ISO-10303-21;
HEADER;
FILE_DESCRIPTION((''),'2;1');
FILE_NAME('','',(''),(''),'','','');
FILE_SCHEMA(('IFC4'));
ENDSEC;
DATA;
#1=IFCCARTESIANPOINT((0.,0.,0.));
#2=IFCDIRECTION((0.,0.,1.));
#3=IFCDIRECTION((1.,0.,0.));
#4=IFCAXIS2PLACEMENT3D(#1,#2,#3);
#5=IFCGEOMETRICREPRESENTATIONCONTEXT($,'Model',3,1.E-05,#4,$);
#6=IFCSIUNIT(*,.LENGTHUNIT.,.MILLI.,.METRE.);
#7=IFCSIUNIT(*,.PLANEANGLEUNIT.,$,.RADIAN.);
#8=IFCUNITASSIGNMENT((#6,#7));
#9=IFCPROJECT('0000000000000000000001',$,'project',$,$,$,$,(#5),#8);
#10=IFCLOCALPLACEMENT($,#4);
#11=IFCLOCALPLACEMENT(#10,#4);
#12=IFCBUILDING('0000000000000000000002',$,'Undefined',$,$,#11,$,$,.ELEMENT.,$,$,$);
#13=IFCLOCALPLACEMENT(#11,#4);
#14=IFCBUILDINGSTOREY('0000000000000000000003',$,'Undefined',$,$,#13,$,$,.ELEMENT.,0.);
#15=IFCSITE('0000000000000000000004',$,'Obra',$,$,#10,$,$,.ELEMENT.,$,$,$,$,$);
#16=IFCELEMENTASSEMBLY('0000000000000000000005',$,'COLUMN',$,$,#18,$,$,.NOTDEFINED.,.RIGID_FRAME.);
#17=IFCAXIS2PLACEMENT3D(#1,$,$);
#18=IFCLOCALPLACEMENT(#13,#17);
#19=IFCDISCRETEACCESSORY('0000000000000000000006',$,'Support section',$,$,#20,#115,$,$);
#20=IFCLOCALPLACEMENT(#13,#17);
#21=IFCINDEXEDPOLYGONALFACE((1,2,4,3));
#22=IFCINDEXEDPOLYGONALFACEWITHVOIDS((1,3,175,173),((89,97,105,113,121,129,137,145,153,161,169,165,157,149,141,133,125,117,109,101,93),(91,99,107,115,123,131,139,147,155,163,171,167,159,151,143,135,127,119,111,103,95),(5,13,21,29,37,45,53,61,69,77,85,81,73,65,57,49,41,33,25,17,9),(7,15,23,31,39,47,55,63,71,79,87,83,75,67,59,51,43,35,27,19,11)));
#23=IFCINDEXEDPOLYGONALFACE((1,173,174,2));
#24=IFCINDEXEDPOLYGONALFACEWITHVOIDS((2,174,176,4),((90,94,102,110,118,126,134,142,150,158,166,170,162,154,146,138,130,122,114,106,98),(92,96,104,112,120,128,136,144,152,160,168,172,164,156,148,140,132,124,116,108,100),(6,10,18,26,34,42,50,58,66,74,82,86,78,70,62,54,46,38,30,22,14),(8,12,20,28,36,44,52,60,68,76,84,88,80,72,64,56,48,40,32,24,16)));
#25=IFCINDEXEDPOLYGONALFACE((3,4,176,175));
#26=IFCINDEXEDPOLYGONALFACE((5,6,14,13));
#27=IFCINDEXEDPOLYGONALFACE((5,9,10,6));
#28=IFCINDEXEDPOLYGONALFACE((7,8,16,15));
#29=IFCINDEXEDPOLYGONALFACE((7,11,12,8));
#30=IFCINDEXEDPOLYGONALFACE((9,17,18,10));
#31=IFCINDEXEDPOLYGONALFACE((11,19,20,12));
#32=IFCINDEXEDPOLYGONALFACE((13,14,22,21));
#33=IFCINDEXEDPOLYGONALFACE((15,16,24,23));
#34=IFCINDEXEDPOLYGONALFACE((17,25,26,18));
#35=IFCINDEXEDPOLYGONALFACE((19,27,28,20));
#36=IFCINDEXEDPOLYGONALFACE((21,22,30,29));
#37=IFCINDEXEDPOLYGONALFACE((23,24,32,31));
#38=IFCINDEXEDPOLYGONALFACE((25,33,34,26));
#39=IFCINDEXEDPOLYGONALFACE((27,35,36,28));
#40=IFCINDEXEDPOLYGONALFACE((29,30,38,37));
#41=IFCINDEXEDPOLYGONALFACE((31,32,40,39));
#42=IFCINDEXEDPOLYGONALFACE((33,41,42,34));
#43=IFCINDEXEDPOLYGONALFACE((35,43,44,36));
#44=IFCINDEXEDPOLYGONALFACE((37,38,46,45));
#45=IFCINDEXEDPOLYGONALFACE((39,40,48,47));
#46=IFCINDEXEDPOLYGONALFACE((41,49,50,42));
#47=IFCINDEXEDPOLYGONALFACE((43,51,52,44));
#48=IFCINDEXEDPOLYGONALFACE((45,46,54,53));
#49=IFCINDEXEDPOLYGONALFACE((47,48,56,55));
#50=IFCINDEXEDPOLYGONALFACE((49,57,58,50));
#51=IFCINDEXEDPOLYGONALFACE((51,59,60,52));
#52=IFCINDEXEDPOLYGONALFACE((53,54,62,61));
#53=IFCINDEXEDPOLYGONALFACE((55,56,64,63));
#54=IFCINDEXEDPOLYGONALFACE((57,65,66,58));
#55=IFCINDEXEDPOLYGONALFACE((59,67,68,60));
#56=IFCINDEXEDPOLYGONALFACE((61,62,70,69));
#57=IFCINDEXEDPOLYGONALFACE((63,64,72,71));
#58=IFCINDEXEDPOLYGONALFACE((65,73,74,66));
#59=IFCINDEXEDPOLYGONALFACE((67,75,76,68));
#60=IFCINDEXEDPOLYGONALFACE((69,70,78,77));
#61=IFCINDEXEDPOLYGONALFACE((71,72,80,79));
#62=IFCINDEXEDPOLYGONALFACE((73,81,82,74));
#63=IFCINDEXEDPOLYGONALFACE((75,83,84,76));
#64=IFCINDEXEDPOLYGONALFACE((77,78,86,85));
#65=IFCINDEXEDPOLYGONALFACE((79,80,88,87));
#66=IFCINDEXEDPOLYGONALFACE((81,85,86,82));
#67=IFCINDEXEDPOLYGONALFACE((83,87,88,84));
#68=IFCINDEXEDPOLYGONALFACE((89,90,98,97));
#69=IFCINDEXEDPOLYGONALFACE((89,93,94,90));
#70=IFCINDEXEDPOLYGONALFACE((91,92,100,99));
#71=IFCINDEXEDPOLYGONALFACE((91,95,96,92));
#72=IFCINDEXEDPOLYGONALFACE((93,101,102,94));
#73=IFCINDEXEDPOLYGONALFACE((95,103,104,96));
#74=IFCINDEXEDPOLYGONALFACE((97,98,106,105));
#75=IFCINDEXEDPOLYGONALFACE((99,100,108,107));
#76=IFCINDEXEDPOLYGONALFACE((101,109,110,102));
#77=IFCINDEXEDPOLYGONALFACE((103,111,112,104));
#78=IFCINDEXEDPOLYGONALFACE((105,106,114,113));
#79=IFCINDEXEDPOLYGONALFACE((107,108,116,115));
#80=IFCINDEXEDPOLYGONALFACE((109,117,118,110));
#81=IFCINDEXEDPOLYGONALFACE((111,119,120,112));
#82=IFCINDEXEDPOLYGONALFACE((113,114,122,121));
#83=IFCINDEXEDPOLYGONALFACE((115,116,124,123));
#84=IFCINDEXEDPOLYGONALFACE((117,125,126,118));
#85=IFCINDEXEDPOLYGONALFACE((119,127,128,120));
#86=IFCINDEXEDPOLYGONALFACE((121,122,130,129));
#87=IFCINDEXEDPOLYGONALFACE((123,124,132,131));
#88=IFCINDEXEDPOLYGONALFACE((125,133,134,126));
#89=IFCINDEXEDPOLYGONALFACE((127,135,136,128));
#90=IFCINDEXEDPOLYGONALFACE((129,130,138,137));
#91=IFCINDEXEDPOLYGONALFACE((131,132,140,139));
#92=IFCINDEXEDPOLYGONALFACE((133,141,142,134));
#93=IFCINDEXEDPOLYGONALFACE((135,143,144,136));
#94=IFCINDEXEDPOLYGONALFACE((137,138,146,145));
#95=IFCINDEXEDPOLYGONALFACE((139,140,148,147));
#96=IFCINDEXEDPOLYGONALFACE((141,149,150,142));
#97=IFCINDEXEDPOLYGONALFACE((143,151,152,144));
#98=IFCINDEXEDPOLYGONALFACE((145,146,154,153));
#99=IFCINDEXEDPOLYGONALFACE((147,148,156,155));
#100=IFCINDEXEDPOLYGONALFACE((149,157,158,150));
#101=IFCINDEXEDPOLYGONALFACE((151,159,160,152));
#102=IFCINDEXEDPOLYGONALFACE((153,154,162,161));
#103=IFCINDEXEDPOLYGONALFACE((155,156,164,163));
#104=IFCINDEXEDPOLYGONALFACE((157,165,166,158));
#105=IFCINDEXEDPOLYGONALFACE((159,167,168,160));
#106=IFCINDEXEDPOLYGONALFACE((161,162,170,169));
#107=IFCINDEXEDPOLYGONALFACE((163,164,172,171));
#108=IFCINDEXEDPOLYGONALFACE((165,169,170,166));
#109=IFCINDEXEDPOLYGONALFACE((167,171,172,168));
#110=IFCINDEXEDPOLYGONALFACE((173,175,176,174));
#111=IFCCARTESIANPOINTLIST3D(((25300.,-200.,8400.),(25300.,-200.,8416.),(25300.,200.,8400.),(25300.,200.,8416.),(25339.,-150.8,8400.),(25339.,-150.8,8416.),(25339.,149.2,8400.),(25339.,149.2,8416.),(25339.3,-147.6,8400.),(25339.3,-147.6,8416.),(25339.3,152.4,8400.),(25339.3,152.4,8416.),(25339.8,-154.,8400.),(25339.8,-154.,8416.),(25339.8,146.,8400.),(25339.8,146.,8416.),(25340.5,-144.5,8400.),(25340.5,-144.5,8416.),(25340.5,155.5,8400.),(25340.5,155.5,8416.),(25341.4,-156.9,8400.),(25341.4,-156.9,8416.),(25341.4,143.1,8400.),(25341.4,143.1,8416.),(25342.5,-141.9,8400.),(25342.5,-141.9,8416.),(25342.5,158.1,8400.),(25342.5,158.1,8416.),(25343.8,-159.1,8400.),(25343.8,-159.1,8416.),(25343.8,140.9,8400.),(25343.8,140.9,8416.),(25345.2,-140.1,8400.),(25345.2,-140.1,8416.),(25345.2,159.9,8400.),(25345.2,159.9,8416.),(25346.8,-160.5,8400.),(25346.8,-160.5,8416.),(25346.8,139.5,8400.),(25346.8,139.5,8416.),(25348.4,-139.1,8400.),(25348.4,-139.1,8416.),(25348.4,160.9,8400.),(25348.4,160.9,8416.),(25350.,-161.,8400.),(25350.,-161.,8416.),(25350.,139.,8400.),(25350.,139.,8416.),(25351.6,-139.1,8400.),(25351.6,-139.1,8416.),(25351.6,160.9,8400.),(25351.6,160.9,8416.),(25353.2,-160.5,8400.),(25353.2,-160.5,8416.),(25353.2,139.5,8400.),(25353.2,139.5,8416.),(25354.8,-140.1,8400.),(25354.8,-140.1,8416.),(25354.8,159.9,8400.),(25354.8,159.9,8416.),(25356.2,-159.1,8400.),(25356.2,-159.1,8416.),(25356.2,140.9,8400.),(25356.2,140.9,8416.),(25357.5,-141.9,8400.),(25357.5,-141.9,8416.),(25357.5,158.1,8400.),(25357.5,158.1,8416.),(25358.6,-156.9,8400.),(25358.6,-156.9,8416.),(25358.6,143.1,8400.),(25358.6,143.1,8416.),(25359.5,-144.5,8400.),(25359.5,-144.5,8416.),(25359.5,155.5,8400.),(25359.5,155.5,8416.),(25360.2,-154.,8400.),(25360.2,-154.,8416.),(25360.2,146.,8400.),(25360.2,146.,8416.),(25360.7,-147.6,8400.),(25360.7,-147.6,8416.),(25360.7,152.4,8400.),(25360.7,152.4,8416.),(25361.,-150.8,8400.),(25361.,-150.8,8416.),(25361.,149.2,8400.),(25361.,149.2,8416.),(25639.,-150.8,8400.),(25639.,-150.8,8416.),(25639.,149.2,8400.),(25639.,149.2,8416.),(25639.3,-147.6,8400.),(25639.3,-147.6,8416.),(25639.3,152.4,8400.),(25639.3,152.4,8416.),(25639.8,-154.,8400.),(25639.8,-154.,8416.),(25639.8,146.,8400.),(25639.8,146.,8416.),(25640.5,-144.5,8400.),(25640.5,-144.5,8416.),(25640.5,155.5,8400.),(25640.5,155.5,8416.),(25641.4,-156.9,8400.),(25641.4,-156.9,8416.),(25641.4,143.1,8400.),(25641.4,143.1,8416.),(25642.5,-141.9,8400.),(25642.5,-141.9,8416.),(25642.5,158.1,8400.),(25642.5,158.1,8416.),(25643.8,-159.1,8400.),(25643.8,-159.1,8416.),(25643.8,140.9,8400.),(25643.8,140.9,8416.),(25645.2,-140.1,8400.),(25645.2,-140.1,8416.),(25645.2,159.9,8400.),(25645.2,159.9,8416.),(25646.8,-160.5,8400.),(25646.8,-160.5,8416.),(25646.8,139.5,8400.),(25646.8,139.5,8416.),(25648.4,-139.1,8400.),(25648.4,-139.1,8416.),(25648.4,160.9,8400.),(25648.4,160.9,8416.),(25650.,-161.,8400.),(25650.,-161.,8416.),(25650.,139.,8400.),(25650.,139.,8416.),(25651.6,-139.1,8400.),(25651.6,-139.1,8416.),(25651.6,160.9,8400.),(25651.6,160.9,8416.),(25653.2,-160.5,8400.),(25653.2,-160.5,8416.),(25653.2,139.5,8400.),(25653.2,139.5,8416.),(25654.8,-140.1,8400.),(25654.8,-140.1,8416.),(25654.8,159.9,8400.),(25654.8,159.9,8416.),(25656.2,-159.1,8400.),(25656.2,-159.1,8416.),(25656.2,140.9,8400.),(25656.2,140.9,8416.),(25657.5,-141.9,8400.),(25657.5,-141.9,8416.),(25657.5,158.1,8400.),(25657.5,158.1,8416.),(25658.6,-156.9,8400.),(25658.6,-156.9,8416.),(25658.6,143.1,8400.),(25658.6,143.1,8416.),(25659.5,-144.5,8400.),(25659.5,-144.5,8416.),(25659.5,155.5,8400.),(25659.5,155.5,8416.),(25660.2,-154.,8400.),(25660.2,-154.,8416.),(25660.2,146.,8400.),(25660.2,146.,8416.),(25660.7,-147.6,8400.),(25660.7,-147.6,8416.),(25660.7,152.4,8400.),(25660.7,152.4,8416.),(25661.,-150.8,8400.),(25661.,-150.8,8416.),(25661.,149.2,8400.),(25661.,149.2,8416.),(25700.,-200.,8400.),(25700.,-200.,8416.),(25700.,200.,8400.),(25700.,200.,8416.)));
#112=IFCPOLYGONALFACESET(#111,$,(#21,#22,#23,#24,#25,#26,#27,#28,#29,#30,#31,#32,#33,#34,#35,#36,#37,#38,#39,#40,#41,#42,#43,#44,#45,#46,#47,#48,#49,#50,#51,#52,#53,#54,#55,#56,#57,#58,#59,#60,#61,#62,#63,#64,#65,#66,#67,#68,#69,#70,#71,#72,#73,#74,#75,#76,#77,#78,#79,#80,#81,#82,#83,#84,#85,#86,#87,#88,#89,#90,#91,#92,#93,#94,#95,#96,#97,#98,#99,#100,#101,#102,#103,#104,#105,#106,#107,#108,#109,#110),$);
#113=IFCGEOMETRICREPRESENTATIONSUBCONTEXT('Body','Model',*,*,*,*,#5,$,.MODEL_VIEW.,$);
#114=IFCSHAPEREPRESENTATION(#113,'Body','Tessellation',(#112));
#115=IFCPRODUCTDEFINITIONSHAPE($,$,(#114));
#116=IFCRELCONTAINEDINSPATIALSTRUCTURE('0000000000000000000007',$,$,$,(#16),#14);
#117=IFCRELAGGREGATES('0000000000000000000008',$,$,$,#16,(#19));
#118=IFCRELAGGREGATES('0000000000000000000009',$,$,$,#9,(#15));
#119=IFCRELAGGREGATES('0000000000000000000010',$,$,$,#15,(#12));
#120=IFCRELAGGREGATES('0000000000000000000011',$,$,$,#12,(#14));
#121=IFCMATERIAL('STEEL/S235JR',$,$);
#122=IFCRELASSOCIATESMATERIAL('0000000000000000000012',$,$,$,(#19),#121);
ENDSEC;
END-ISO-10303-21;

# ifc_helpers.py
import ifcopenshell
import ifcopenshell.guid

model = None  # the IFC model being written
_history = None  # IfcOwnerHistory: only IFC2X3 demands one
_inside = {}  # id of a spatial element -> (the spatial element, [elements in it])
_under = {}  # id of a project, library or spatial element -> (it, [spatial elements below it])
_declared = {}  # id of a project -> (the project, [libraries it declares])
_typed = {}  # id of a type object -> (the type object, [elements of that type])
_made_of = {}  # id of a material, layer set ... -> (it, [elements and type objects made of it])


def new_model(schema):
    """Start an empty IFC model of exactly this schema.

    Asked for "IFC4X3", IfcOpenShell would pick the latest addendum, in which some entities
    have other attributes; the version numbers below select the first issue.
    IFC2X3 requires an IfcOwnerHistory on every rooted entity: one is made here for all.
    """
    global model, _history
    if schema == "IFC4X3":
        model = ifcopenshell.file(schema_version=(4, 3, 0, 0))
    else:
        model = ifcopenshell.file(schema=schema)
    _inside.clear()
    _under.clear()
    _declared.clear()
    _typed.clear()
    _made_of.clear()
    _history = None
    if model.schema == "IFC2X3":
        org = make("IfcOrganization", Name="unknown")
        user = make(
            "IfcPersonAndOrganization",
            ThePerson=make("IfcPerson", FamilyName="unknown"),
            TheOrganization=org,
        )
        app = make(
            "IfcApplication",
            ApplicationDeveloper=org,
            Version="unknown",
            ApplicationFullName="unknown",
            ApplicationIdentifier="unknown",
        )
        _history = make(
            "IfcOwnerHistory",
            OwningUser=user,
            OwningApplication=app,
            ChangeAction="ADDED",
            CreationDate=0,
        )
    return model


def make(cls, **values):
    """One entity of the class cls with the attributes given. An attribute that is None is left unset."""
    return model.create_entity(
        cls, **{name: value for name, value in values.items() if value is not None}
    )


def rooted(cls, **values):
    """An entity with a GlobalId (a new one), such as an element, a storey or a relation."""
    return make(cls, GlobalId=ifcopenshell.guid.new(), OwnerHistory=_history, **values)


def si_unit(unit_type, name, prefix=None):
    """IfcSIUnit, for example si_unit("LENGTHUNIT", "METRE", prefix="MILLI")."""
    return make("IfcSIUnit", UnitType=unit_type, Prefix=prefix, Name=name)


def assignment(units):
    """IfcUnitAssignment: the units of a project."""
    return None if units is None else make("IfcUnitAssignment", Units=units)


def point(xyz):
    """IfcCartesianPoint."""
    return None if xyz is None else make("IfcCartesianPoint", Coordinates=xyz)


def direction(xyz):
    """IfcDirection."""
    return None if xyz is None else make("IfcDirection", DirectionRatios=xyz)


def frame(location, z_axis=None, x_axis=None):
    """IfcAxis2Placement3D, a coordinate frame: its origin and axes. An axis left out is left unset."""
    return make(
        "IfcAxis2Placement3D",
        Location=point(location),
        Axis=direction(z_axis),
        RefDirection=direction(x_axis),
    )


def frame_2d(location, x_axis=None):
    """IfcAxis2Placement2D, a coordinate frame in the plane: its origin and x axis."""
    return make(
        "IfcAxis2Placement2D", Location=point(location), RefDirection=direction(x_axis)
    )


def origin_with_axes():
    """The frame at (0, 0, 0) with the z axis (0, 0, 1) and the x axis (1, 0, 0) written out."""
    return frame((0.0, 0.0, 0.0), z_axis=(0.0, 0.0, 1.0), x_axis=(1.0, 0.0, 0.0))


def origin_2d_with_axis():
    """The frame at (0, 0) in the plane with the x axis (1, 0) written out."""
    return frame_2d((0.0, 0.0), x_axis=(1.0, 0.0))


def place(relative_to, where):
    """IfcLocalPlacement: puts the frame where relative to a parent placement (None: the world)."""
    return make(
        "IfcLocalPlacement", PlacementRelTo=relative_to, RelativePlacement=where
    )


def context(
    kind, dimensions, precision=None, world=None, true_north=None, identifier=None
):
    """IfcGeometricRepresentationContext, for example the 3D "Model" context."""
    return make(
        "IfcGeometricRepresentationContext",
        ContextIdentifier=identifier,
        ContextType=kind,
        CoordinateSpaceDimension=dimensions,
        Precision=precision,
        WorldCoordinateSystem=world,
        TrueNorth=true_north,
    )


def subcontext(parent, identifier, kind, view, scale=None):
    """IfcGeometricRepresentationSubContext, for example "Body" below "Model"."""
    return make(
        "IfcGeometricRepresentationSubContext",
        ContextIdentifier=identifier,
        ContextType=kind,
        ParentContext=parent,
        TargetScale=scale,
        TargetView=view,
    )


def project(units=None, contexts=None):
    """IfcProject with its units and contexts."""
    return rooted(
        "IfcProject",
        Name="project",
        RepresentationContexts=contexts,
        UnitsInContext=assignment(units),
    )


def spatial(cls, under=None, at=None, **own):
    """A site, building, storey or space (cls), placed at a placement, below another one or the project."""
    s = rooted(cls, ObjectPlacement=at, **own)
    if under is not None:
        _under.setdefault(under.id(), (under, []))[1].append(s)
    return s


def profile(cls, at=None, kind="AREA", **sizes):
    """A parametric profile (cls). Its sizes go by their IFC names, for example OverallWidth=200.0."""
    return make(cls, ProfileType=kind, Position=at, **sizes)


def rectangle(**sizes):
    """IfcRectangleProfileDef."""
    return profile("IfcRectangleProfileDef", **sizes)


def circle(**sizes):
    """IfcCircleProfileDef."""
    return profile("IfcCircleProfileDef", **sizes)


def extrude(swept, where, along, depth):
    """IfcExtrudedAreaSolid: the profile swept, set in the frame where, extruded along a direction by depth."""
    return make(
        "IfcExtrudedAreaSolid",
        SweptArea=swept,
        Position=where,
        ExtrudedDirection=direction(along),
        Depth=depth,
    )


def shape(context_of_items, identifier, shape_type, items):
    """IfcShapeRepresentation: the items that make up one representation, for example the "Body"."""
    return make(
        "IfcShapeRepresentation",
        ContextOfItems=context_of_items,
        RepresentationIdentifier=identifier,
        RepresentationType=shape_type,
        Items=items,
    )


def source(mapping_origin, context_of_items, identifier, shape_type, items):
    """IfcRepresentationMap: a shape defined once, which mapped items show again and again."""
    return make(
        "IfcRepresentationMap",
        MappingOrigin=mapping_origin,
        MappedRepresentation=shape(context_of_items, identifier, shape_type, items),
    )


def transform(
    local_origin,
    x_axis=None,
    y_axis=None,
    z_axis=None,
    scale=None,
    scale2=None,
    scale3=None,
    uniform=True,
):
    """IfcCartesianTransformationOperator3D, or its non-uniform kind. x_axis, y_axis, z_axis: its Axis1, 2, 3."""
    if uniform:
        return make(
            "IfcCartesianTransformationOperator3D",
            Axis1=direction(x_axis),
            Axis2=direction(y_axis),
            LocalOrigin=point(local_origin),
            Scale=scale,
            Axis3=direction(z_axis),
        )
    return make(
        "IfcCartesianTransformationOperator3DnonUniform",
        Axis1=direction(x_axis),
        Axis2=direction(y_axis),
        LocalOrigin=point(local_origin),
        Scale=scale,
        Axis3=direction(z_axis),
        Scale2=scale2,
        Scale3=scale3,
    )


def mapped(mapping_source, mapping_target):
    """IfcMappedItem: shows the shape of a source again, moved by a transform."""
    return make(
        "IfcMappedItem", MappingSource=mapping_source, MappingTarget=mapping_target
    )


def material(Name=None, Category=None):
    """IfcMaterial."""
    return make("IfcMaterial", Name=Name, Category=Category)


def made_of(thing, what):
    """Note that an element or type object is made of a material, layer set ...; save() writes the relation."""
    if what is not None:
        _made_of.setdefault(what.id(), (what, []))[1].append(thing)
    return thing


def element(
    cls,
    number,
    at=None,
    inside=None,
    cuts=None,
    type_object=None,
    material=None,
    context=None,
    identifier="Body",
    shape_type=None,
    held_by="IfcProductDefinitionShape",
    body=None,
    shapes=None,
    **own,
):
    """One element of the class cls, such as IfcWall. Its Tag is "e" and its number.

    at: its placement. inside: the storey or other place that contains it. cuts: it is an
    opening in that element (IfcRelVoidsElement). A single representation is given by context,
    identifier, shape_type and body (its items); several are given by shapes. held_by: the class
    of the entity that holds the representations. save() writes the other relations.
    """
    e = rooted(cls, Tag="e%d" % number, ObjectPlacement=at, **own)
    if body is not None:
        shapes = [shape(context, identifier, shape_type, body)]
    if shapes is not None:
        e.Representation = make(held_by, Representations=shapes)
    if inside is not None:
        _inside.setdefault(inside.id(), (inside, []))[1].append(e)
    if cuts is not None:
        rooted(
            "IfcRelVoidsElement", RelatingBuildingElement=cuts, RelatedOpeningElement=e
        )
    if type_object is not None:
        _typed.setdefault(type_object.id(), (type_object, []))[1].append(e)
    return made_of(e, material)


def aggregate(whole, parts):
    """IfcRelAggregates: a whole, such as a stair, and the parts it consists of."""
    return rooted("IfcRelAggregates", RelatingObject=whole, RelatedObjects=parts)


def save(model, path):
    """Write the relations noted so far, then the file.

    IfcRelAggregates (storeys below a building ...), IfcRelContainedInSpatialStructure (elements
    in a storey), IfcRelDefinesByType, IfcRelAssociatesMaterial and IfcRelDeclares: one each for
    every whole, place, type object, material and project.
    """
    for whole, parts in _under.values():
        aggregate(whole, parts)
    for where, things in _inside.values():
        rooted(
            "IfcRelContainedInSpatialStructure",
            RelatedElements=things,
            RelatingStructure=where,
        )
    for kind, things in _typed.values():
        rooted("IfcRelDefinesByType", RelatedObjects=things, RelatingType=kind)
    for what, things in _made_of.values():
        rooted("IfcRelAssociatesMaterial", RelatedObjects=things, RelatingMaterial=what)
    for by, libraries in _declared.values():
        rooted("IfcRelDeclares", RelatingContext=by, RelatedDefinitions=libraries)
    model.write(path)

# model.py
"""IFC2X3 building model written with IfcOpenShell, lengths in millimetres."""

from ifc_helpers import new_model, si_unit, frame, origin_with_axes, origin_2d_with_axis, place, context, subcontext, project, spatial, rectangle, circle, extrude, source, transform, mapped, material, element, aggregate, save


model = new_model("IFC2X3")

# Units and contexts
model_context = context("Model", 3, precision=1e-05, world=origin_with_axes())
body_context = subcontext(model_context, "Body", "Model", "MODEL_VIEW")
ifc_project = project(units=[si_unit("LENGTHUNIT", "METRE", prefix="MILLI"), si_unit("PLANEANGLEUNIT", "RADIAN")], contexts=[model_context])

# Site, building, storey
site_placement = place(None, origin_with_axes())
site = spatial("IfcSite", under=ifc_project, at=site_placement, Name="Obra", CompositionType="ELEMENT")
building_placement = place(site_placement, origin_with_axes())
building = spatial("IfcBuilding", under=site, at=building_placement, Name="Undefined", CompositionType="ELEMENT")
storey_placement = place(building_placement, origin_with_axes())
storey = spatial("IfcBuildingStorey", under=building, at=storey_placement, Name="Undefined", CompositionType="ELEMENT", Elevation=0.0)

# Element assembly
assembly_1_placement = place(storey_placement, origin_with_axes())
assembly_1 = element("IfcElementAssembly", 1, at=assembly_1_placement, inside=storey, Name="COLUMN", AssemblyPlace="NOTDEFINED", PredefinedType="RIGID_FRAME")
ifc_material_1 = material(Name="STEEL/S235JR")

# Discrete accessory, opening
discrete_accessory_1_placement = place(assembly_1_placement, frame((25500.0, -200.0, 8408.0), z_axis=(-1.0, 0.0, 0.0), x_axis=(0.0, 1.0, 0.0)))
discrete_accessory_1 = element("IfcDiscreteAccessory", 2, at=discrete_accessory_1_placement, material=ifc_material_1, Name="Support section", context=body_context, shape_type="SweptSolid", body=[
    extrude(rectangle(XDim=16.0, YDim=400.0, at=origin_2d_with_axis()), frame((400.0, 0.0, 0.0), z_axis=(-1.0, 0.0, 0.0), x_axis=(0.0, -1.0, 0.0)), (0.0, 0.0, 1.0), 400.0),
])
shared_shape_1 = source(origin_with_axes(), body_context, "Body", "SweptSolid", [
    extrude(circle(Radius=11.0, at=origin_2d_with_axis()), frame((0.0, -0.1, 0.0), z_axis=(0.0, 1.0, 0.0), x_axis=(1.0, 0.0, 0.0)), (0.0, 0.0, 1.0), 16.2),
])
opening_1_placement = place(assembly_1_placement, frame((25500.0, 152.5, 8416.0), z_axis=(1.0, 0.0, 0.0), x_axis=(0.0, -1.0, 0.0)))
element("IfcOpeningElement", 3, at=opening_1_placement, cuts=discrete_accessory_1, ObjectType="Opening", context=body_context, shape_type="MappedRepresentation", body=[
    mapped(shared_shape_1, transform((2.5, 0.0, 150.0))),
    mapped(shared_shape_1, transform((2.5, 0.0, -150.0))),
    mapped(shared_shape_1, transform((302.5, 0.0, 150.0))),
    mapped(shared_shape_1, transform((302.5, 0.0, -150.0))),
])
aggregate(assembly_1, [discrete_accessory_1])

save(model, "model.ifc")
